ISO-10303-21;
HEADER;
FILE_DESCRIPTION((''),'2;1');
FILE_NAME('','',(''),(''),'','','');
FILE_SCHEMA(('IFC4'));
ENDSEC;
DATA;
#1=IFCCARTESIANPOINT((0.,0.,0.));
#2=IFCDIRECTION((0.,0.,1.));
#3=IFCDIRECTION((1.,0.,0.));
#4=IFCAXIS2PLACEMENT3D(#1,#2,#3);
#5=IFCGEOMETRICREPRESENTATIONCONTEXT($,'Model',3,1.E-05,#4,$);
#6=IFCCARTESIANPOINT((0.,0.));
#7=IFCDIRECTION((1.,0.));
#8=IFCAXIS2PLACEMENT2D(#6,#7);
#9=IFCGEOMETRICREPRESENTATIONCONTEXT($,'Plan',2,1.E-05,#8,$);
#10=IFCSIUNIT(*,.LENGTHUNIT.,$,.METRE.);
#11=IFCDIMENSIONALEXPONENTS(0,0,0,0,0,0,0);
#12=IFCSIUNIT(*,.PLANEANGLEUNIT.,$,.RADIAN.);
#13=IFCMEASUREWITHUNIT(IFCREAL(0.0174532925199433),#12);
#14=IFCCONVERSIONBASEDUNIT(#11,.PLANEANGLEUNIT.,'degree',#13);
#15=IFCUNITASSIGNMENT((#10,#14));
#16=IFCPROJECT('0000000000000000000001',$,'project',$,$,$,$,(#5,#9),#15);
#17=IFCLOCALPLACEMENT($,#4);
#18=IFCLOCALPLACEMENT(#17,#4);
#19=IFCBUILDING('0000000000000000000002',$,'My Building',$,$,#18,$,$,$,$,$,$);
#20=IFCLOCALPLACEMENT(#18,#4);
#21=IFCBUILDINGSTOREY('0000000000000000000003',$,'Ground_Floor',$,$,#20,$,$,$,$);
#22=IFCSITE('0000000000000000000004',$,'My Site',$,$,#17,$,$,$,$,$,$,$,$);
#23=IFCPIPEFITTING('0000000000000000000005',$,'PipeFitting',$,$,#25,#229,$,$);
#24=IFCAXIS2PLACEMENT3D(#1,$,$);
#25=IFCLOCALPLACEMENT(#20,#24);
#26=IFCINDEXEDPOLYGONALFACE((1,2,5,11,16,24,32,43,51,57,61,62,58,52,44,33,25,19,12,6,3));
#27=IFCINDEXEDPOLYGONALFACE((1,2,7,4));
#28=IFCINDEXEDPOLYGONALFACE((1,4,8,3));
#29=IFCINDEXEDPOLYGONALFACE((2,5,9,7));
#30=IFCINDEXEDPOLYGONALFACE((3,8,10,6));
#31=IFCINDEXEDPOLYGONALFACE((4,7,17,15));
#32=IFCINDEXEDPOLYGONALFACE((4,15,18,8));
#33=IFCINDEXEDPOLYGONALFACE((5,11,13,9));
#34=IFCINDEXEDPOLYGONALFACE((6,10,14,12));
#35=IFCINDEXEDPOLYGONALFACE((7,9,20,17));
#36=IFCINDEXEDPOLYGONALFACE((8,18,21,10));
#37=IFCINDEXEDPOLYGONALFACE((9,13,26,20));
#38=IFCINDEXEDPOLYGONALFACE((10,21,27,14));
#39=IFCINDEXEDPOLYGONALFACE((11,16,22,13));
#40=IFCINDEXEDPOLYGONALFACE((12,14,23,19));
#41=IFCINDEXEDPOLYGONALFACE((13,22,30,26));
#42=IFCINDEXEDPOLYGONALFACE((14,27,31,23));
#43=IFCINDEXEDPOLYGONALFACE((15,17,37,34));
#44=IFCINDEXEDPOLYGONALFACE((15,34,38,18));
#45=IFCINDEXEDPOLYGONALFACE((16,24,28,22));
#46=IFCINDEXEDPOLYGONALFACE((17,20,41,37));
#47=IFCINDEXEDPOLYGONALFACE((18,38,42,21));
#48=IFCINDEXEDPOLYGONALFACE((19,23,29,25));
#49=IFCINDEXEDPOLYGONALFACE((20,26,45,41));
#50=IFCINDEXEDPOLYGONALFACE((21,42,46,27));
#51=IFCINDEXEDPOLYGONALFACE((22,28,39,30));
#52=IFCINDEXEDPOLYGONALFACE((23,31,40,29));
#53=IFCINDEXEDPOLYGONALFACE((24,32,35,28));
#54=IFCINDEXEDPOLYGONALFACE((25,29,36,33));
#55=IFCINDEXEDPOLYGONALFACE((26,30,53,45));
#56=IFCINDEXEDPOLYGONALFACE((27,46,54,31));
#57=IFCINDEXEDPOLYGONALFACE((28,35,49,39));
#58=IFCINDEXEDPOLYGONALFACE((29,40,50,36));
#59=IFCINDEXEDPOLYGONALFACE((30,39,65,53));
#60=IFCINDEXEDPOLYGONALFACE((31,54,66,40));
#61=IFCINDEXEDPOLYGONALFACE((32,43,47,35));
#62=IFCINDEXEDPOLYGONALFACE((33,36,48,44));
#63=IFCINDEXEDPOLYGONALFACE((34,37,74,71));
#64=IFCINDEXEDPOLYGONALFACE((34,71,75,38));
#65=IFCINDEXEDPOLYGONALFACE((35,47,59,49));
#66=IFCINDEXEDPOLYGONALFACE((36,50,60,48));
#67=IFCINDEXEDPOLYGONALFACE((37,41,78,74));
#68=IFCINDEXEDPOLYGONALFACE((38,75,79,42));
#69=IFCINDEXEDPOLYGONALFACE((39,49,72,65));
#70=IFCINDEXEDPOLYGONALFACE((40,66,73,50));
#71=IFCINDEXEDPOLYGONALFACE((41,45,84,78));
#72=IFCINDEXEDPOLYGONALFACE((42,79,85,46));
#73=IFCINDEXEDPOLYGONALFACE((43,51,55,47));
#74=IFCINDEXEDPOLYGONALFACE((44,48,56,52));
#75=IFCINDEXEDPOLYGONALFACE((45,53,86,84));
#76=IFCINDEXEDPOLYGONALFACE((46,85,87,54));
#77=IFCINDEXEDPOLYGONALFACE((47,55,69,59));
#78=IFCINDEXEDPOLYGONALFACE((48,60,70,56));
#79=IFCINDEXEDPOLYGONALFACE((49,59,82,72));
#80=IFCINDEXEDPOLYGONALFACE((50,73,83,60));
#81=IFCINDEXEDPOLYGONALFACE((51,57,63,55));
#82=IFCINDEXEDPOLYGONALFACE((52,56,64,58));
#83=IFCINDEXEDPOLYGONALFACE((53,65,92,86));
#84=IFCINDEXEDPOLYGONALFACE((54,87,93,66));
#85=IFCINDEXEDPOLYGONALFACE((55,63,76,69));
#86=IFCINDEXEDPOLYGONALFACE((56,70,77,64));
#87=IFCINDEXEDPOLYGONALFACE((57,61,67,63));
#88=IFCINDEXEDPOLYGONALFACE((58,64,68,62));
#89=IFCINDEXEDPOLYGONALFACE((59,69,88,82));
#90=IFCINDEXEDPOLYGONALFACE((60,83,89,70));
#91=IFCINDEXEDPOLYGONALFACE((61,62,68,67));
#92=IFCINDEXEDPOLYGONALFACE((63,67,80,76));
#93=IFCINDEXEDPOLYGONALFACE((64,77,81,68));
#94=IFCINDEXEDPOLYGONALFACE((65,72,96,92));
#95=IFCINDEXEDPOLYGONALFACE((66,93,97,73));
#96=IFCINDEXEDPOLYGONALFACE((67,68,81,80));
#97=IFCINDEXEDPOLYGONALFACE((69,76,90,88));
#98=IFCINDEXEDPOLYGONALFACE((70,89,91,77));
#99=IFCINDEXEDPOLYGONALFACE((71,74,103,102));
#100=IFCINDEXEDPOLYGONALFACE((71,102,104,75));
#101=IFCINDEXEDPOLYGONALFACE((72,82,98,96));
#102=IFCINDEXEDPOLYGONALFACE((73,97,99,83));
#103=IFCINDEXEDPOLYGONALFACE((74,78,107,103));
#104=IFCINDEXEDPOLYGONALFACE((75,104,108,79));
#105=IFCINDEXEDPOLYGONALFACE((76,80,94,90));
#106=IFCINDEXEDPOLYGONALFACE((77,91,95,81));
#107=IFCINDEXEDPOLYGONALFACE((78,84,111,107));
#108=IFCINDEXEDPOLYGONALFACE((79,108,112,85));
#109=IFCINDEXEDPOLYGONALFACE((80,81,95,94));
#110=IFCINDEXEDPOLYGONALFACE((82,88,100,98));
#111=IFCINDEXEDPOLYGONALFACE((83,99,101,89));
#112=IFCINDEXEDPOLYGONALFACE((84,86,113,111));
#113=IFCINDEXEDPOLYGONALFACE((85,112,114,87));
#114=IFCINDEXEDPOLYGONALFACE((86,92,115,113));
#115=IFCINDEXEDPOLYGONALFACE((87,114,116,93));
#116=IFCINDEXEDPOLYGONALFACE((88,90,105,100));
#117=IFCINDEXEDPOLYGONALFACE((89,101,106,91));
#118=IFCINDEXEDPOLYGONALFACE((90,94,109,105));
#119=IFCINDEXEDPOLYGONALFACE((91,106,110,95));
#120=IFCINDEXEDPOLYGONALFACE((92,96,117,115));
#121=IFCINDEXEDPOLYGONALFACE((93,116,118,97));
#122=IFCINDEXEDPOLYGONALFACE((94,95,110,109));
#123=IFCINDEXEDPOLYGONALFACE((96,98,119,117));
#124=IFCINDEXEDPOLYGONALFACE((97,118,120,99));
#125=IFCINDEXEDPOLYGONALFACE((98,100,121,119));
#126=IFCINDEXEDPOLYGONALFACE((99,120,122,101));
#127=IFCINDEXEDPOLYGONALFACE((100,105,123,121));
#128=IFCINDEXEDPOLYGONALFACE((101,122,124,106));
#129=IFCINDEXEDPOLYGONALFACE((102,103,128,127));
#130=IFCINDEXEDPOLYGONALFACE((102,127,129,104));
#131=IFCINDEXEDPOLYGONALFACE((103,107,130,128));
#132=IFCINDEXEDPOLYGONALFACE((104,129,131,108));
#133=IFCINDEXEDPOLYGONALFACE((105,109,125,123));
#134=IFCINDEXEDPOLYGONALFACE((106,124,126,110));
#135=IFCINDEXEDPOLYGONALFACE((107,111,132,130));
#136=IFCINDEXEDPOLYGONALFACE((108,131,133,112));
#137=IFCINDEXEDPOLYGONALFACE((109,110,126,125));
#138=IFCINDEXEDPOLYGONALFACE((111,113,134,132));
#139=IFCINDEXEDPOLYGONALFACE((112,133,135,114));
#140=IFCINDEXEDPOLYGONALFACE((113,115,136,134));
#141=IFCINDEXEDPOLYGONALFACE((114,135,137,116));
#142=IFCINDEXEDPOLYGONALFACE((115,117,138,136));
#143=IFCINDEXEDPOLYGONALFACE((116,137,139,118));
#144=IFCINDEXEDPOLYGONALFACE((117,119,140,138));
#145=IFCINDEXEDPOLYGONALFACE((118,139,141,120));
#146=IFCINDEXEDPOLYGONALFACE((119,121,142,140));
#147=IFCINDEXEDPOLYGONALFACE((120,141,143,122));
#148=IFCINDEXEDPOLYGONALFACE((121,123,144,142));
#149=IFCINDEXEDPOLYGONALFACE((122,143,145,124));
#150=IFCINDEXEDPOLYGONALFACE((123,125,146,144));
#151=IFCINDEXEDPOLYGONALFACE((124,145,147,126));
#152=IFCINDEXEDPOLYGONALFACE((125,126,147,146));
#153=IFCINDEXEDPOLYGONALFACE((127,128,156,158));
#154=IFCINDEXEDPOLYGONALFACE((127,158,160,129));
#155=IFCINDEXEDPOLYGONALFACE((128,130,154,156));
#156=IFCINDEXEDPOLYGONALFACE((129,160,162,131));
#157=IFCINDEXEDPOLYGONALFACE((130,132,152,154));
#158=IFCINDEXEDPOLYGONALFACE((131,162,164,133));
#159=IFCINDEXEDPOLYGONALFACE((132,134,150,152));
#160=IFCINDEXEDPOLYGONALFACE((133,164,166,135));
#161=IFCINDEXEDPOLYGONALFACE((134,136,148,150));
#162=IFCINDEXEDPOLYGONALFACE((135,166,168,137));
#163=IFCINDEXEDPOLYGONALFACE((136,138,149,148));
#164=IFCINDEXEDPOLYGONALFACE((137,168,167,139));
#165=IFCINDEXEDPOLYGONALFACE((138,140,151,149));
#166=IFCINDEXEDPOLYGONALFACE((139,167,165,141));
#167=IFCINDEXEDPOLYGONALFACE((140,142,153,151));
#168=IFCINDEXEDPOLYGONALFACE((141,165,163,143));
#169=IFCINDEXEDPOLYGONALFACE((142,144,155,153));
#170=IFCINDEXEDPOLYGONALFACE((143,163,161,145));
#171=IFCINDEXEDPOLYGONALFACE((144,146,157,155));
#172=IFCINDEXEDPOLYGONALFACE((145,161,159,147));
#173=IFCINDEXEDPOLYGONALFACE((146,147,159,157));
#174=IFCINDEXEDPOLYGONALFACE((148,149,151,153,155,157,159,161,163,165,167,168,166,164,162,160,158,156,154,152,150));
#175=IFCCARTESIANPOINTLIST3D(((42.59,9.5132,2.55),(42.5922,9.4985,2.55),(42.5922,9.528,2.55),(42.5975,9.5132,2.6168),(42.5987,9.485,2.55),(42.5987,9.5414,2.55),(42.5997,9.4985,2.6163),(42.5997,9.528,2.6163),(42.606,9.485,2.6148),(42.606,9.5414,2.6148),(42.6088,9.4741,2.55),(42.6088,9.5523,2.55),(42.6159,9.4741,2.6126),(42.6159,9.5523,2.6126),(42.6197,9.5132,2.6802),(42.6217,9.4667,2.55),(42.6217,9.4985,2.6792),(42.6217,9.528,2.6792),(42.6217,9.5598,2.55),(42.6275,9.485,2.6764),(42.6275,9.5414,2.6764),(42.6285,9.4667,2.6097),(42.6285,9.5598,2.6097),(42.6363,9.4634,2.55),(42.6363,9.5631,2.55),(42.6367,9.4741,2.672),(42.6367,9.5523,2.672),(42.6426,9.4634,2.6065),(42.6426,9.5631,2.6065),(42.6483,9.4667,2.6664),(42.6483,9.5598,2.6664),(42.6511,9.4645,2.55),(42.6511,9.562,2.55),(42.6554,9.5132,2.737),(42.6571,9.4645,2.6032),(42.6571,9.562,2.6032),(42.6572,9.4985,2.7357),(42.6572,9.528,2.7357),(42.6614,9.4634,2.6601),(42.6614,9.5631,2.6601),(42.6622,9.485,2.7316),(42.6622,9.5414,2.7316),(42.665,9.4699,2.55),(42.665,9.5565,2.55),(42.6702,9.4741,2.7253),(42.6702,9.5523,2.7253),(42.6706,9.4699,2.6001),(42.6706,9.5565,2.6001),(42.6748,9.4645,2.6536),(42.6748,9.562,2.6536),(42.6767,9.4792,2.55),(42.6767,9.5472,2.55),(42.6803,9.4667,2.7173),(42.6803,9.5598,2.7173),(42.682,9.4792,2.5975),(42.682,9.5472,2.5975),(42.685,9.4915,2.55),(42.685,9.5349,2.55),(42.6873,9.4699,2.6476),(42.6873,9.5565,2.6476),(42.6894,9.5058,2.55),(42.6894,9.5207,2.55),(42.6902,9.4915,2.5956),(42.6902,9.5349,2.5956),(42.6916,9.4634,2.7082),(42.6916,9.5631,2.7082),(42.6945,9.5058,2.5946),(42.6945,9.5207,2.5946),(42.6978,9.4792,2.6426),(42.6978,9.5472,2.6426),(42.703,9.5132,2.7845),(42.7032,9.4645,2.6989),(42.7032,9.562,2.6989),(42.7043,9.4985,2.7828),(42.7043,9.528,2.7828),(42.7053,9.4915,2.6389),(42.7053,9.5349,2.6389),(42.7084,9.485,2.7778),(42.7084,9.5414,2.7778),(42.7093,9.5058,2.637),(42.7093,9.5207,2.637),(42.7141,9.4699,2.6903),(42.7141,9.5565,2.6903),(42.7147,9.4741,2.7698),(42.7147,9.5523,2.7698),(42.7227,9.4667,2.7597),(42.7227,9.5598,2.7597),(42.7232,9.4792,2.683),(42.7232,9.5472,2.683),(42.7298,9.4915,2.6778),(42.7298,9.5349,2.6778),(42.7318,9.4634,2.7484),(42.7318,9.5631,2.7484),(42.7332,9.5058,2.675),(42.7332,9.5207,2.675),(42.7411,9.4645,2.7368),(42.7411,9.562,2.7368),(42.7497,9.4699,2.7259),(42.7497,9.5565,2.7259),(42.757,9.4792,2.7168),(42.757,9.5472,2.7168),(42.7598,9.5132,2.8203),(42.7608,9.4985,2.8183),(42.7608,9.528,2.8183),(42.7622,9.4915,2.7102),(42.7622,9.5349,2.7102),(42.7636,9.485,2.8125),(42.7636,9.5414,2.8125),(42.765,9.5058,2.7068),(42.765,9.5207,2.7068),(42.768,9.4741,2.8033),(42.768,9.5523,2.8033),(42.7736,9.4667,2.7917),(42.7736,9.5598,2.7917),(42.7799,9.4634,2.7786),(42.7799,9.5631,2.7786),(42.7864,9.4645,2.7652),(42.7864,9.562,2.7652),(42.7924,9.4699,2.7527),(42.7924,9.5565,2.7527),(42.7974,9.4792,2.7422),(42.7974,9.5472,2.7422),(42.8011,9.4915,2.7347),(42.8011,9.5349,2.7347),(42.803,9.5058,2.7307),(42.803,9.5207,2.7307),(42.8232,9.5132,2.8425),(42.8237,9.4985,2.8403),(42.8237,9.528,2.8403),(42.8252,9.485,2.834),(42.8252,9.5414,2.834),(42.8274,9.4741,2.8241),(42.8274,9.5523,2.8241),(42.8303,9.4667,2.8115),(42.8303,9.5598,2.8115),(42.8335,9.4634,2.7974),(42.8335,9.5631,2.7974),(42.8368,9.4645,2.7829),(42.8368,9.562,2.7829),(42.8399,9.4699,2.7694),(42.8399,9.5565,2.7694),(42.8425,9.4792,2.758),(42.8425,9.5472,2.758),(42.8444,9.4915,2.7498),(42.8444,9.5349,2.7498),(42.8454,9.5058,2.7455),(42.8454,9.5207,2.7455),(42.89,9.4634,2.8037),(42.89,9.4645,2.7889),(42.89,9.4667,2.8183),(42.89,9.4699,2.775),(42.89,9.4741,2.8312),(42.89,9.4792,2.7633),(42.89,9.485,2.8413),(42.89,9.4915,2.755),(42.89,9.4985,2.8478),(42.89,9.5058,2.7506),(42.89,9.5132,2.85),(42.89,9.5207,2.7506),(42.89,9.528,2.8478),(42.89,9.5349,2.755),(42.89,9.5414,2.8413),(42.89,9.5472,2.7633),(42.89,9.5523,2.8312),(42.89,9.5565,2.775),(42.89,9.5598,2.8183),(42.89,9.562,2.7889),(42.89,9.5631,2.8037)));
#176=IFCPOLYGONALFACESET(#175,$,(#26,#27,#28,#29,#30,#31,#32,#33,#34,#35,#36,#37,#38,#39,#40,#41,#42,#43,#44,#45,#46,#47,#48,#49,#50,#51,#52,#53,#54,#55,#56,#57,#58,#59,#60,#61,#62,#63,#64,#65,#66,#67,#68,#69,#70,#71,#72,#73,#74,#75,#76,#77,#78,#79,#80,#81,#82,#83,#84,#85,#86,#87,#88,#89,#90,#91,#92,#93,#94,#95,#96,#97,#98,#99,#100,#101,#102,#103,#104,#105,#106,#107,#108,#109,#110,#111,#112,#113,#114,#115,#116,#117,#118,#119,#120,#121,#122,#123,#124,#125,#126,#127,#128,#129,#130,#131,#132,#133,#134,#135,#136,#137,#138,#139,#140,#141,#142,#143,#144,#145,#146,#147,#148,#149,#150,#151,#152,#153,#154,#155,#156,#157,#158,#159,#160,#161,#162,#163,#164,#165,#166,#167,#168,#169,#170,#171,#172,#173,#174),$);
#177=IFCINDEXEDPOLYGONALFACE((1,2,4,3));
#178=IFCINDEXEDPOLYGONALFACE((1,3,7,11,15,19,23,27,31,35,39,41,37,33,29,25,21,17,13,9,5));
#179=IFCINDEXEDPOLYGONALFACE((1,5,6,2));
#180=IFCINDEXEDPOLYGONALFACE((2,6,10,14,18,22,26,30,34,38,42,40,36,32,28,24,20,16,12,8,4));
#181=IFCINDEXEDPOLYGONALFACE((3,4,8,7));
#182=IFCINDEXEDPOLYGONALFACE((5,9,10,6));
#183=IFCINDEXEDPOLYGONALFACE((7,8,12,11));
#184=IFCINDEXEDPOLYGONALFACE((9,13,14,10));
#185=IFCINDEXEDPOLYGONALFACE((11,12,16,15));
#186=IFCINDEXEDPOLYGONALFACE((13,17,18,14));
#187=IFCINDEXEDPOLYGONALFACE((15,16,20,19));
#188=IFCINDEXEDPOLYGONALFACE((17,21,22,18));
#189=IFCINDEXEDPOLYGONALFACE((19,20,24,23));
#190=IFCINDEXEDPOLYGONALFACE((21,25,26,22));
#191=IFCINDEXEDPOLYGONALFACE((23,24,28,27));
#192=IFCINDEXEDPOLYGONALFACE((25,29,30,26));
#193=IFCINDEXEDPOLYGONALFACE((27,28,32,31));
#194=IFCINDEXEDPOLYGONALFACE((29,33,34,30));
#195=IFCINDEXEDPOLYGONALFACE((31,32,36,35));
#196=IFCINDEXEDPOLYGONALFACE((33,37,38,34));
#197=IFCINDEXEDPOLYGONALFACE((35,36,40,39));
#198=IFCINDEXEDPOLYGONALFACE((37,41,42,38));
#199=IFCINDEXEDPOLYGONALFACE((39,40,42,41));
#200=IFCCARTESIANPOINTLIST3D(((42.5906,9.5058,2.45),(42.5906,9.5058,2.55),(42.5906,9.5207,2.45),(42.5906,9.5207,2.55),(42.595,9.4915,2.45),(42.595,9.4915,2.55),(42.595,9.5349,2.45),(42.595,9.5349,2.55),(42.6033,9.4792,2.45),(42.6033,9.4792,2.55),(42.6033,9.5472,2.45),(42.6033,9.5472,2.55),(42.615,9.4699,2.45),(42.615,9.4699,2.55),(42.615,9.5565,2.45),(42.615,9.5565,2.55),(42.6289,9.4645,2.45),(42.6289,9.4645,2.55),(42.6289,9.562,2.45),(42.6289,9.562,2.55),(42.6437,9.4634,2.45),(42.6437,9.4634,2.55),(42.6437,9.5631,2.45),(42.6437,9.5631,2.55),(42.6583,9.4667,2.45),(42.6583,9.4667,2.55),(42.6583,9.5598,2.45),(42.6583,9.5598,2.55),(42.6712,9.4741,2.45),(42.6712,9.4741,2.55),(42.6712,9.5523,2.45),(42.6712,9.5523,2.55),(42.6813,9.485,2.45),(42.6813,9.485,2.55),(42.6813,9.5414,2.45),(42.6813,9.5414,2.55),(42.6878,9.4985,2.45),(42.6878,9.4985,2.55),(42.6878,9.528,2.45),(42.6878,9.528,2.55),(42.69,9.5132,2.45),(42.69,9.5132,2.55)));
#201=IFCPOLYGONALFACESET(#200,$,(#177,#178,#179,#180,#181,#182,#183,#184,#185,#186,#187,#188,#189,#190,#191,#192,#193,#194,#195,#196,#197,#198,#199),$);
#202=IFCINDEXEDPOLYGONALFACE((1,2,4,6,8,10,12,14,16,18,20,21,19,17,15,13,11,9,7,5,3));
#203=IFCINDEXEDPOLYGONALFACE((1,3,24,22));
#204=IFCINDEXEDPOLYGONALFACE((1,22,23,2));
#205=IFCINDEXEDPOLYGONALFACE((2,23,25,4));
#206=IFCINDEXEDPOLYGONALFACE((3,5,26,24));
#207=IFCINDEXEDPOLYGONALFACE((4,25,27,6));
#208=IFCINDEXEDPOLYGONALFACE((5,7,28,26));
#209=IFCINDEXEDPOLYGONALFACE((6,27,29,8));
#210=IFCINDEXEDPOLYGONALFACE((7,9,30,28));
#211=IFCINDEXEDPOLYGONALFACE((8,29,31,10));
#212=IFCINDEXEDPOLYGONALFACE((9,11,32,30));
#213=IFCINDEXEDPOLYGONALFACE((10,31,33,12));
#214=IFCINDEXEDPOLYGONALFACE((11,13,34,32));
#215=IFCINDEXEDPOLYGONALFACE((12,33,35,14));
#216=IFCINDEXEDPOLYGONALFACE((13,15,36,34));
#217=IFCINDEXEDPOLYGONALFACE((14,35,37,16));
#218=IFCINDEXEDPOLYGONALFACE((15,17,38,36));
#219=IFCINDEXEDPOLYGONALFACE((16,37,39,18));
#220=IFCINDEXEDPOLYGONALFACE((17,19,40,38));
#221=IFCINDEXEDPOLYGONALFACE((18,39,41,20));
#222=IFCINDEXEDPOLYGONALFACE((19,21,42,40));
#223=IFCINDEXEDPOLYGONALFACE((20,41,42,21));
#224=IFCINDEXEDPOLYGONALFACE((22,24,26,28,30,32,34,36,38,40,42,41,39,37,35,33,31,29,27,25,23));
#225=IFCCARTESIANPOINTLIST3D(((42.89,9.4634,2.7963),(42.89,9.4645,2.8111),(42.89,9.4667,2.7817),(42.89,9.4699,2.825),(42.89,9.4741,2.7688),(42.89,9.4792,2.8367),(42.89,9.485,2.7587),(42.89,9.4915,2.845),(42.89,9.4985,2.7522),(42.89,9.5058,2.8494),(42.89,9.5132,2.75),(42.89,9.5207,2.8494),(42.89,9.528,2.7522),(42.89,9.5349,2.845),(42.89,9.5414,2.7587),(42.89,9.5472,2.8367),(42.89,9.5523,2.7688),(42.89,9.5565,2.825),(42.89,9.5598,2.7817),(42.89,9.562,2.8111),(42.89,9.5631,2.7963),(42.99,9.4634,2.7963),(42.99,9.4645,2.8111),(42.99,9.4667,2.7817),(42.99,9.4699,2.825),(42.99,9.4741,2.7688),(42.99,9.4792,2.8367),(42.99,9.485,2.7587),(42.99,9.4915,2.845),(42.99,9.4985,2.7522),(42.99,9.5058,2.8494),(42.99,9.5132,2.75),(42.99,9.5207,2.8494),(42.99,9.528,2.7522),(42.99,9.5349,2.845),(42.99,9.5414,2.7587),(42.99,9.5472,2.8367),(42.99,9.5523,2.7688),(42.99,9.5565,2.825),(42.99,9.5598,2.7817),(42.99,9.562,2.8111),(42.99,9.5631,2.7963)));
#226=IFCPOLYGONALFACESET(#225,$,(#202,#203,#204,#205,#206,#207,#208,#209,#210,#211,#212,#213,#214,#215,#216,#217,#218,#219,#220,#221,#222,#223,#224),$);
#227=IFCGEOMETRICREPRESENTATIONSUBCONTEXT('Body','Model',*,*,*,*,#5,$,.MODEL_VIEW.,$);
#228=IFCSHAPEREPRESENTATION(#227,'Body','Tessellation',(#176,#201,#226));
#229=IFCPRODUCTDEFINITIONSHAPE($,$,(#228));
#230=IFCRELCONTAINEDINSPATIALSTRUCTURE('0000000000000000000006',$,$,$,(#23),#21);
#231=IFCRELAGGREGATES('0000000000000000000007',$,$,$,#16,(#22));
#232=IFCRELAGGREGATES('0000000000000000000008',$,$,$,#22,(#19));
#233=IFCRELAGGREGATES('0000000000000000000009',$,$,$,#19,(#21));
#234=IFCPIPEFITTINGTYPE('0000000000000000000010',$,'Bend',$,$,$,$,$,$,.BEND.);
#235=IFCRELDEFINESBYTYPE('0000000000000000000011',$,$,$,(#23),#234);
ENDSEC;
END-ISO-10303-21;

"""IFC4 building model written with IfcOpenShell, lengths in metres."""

from ifc_helpers import new_model, entity, si_unit, converted_unit, frame, origin_with_axes, origin_2d_with_axis, place, context, subcontext, project, spatial, circle, extrude, source, transform, mapped, type_object, type_shapes, element, save


model = new_model("IFC4")

# Units and contexts
model_context = context("Model", 3, precision=1e-05, world=origin_with_axes())
plan_context = context("Plan", 2, precision=1e-05, world=origin_2d_with_axis())
body_context = subcontext(model_context, "Body", "Model", "MODEL_VIEW")
ifc_project = project(units=[si_unit("LENGTHUNIT", "METRE"), converted_unit("PLANEANGLEUNIT", "degree", entity("IfcReal", 0.0174532925199433), si_unit("PLANEANGLEUNIT", "RADIAN"), dimensions=[0, 0, 0, 0, 0, 0, 0])], contexts=[model_context, plan_context])

# Site, building, storey
site_placement = place(None, origin_with_axes())
site = spatial("IfcSite", under=ifc_project, at=site_placement, Name="My Site")
building_placement = place(site_placement, origin_with_axes())
building = spatial("IfcBuilding", under=site, at=building_placement, Name="My Building")
storey_placement = place(building_placement, origin_with_axes())
storey = spatial("IfcBuildingStorey", under=building, at=storey_placement, Name="Ground_Floor")

# Pipe fitting
pipe_fitting_type = type_object("IfcPipeFittingType", Name="Bend", PredefinedType="BEND")
shared_shape_1 = source(origin_with_axes(), body_context, "Body", "SolidModel", [
    entity("IfcSweptDiskSolid", entity("IfcIndexedPolyCurve", entity("IfcCartesianPointList3D", [[0.0, 0.0, -0.1], [0.0732, 0.0, -0.2768], [0.25, 0.0, -0.35]]), [entity("IfcArcIndex", [1, 2, 3])]), 0.05),
    extrude(circle(Radius=0.05), origin_with_axes(), (0.0, 0.0, -1.0), 0.1),
    extrude(circle(Radius=0.05), frame((0.25, 0.0, -0.35), z_axis=(1.0, 0.0, 0.0), x_axis=(0.0, 0.0, 1.0)), (0.0, 0.0, 1.0), 0.1),
])
type_shapes(pipe_fitting_type, [shared_shape_1])
for number, where, z_axis, x_axis, name in (
    (1, (42.64, 9.5132, 2.45), (0.0, 0.000001, -1.0), (1.0, -0.000001, 0.0), "PipeFitting"),
):
    element("IfcPipeFitting", number, at=place(storey_placement, frame(where, z_axis=z_axis, x_axis=x_axis)), inside=storey, type_object=pipe_fitting_type, Name=name, context=body_context, shape_type="MappedRepresentation", body=[
        mapped(shared_shape_1, transform((0.0, 0.0, 0.0), x_axis=(1.0, 0.0, 0.0), y_axis=(0.0, 1.0, 0.0), z_axis=(0.0, 0.0, 1.0), scale=1.0)),
    ])

save(model, "model.ifc")
